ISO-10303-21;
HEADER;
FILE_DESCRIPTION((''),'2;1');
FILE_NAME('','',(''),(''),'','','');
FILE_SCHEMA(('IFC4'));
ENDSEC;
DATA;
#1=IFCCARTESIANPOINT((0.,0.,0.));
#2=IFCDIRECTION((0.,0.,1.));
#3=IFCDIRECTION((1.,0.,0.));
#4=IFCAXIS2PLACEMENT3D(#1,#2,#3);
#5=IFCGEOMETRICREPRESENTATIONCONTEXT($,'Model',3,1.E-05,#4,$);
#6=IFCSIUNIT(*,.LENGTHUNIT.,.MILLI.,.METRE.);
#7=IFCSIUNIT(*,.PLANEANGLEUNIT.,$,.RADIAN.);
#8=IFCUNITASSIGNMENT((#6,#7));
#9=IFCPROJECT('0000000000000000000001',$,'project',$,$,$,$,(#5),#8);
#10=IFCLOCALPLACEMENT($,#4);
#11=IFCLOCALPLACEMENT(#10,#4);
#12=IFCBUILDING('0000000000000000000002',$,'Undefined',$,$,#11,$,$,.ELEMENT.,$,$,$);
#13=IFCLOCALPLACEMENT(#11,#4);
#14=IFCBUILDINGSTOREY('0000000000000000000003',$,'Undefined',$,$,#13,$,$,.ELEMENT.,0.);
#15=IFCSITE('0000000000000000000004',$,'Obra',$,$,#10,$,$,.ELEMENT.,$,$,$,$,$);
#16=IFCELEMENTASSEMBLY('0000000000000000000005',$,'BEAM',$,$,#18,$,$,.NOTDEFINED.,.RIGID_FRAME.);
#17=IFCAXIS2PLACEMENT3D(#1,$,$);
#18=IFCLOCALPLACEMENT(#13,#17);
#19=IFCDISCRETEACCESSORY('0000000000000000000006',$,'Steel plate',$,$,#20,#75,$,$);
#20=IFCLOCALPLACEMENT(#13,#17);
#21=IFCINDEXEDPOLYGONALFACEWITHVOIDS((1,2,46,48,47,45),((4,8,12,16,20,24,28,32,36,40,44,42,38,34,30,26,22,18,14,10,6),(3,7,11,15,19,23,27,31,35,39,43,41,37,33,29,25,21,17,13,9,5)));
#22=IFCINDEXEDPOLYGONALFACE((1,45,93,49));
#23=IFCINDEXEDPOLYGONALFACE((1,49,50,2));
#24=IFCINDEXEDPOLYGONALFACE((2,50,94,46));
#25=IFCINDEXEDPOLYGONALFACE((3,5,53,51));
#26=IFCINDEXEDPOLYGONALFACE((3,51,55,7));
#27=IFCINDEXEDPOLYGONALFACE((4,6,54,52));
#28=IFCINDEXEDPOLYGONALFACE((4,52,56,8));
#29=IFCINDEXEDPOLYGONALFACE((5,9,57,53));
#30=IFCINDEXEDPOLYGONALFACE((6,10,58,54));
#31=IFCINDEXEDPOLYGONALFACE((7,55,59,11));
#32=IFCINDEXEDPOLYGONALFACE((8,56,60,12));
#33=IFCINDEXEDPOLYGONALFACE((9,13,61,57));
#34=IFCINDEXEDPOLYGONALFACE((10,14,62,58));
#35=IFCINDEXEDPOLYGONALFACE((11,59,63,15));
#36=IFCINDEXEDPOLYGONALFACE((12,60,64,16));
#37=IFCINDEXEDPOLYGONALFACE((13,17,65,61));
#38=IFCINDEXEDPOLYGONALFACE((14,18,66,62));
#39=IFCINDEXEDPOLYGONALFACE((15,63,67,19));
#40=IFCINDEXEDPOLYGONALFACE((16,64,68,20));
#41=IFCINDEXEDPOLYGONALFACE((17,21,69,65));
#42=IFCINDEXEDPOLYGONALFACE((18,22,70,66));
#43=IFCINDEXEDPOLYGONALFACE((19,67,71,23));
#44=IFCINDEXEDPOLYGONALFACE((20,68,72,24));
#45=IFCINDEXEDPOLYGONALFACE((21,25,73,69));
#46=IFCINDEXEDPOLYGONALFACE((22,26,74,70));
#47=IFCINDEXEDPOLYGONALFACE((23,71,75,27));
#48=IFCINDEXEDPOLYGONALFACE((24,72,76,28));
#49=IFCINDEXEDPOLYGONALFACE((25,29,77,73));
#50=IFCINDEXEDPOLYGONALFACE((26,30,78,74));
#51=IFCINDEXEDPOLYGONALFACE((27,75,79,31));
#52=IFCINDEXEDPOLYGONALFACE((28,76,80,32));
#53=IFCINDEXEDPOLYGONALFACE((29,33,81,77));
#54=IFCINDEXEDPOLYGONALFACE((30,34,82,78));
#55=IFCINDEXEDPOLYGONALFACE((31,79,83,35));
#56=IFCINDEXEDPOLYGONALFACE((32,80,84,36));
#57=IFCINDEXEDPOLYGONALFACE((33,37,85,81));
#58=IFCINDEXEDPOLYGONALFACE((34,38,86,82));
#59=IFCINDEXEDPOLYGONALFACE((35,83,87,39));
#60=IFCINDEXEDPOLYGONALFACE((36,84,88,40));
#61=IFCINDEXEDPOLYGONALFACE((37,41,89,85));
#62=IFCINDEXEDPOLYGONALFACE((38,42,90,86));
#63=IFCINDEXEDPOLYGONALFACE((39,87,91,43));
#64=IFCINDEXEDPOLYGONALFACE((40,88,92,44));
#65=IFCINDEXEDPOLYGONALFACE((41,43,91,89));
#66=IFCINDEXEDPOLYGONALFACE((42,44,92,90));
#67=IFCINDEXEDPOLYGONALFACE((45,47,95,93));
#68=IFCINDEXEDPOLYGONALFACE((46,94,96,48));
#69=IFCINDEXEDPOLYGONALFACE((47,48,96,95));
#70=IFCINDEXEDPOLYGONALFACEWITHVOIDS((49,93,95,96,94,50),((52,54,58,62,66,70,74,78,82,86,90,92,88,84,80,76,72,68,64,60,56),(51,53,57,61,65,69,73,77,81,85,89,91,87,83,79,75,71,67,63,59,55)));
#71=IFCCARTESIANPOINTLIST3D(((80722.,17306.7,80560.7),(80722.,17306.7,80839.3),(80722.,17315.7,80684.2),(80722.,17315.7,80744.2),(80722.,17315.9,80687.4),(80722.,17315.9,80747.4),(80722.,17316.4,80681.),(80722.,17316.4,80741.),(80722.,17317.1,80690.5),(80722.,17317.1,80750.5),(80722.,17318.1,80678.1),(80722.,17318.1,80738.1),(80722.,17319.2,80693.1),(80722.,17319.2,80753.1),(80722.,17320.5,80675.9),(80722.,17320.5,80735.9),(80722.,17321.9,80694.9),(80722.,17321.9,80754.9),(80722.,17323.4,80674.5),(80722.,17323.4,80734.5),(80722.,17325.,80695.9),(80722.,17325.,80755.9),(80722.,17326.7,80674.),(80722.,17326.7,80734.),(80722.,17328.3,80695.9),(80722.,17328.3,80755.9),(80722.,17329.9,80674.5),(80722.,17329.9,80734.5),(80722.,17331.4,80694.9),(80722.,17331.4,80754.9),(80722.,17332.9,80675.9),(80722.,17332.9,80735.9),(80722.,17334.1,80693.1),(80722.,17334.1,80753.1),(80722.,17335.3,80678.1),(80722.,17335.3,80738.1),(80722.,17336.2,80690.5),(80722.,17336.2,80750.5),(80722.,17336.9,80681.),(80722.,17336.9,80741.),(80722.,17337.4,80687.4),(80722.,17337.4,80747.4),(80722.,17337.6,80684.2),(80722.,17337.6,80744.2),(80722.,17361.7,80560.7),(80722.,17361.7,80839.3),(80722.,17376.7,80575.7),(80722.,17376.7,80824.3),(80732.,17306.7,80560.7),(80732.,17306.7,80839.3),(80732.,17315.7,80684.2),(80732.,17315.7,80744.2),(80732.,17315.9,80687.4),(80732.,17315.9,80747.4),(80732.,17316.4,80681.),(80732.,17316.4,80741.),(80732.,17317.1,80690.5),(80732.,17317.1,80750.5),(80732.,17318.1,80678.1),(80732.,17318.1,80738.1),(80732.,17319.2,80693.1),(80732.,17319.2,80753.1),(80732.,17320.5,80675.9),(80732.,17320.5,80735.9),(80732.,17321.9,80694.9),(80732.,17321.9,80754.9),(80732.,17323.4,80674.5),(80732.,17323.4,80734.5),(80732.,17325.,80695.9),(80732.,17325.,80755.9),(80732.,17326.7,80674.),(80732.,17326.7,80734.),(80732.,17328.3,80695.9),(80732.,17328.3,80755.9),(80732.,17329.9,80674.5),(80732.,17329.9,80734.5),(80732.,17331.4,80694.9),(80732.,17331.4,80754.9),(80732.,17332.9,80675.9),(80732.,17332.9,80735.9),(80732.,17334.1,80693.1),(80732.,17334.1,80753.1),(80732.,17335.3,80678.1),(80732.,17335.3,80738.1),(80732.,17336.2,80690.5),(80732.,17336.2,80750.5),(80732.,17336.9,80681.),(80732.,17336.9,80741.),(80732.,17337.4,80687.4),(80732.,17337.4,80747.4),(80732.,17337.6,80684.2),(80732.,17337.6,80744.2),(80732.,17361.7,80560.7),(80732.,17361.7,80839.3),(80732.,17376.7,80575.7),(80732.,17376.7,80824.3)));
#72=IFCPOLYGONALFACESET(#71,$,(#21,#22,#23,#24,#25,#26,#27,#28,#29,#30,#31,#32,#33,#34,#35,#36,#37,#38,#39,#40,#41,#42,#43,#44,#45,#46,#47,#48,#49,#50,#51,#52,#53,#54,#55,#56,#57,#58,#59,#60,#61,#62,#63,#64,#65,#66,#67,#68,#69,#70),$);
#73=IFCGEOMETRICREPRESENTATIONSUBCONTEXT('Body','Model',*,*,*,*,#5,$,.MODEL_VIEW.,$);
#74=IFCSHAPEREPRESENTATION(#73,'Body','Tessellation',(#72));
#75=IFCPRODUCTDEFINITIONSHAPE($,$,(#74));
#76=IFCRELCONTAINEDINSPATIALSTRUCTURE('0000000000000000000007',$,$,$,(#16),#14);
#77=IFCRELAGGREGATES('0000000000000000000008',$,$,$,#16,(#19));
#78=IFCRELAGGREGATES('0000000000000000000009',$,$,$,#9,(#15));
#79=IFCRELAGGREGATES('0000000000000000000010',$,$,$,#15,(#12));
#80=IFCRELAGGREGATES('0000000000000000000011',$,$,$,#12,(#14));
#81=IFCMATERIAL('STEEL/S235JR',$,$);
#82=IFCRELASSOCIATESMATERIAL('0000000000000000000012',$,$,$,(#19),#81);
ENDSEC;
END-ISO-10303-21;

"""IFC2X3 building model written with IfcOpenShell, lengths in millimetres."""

from ifc_helpers import new_model, si_unit, frame, origin_with_axes, origin_2d_with_axis, place, context, subcontext, project, spatial, polyline, circle, outline, extrude, source, transform, mapped, material, element, aggregate, save


model = new_model("IFC2X3")

# Units and contexts
model_context = context("Model", 3, precision=1e-05, world=origin_with_axes())
body_context = subcontext(model_context, "Body", "Model", "MODEL_VIEW")
ifc_project = project(units=[si_unit("LENGTHUNIT", "METRE", prefix="MILLI"), si_unit("PLANEANGLEUNIT", "RADIAN")], contexts=[model_context])

# Site, building, storey
site_placement = place(None, origin_with_axes())
site = spatial("IfcSite", under=ifc_project, at=site_placement, Name="Obra", CompositionType="ELEMENT")
building_placement = place(site_placement, origin_with_axes())
building = spatial("IfcBuilding", under=site, at=building_placement, Name="Undefined", CompositionType="ELEMENT")
storey_placement = place(building_placement, origin_with_axes())
storey = spatial("IfcBuildingStorey", under=building, at=storey_placement, Name="Undefined", CompositionType="ELEMENT", Elevation=0.0)

# Shared definitions
ifc_material_1 = material(Name="STEEL/S235JR")

# Element assembly, discrete accessory, opening
assembly_1_placement = place(storey_placement, origin_with_axes())
assembly_1 = element("IfcElementAssembly", 1, at=assembly_1_placement, inside=storey, Name="BEAM", AssemblyPlace="NOTDEFINED", PredefinedType="RIGID_FRAME")
discrete_accessory_1_placement = place(assembly_1_placement, frame((80727.0, 17306.7, 80560.7), z_axis=(1.0, 0.0, 0.0), x_axis=(0.0, 1.0, 0.0)))
discrete_accessory_1 = element("IfcDiscreteAccessory", 2, at=discrete_accessory_1_placement, material=ifc_material_1, Name="Steel plate", context=body_context, shape_type="SweptSolid", body=[
    extrude(outline(polyline([(0.0, 0.0), (55.0, 0.0), (70.0, 15.0), (70.0, 263.6), (55.0, 278.6), (0.0, 278.6), (0.0, 0.0)])), frame((0.0, 0.0, -5.0), z_axis=(0.0, 0.0, 1.0), x_axis=(1.0, 0.0, 0.0)), (0.0, 0.0, 1.0), 10.0),
])
shared_shape_1 = source(origin_with_axes(), body_context, "Body", "SweptSolid", [
    extrude(circle(Radius=11.0, at=origin_2d_with_axis()), frame((0.0, -13.4, 0.0), z_axis=(0.0, 1.0, 0.0), x_axis=(1.0, 0.0, 0.0)), (0.0, 0.0, 1.0), 10.2),
])
opening_1_placement = place(assembly_1_placement, frame((80735.3, 17366.7, 80850.0), z_axis=(0.0, -1.0, 0.0), x_axis=(0.0, 0.0, -1.0)))
element("IfcOpeningElement", 3, at=opening_1_placement, cuts=discrete_accessory_1, ObjectType="Opening", context=body_context, shape_type="MappedRepresentation", body=[
    mapped(shared_shape_1, transform((105.0, 0.0, 40.0))),
    mapped(shared_shape_1, transform((165.0, 0.0, 40.0))),
])
aggregate(assembly_1, [discrete_accessory_1])

save(model, "model.ifc")
